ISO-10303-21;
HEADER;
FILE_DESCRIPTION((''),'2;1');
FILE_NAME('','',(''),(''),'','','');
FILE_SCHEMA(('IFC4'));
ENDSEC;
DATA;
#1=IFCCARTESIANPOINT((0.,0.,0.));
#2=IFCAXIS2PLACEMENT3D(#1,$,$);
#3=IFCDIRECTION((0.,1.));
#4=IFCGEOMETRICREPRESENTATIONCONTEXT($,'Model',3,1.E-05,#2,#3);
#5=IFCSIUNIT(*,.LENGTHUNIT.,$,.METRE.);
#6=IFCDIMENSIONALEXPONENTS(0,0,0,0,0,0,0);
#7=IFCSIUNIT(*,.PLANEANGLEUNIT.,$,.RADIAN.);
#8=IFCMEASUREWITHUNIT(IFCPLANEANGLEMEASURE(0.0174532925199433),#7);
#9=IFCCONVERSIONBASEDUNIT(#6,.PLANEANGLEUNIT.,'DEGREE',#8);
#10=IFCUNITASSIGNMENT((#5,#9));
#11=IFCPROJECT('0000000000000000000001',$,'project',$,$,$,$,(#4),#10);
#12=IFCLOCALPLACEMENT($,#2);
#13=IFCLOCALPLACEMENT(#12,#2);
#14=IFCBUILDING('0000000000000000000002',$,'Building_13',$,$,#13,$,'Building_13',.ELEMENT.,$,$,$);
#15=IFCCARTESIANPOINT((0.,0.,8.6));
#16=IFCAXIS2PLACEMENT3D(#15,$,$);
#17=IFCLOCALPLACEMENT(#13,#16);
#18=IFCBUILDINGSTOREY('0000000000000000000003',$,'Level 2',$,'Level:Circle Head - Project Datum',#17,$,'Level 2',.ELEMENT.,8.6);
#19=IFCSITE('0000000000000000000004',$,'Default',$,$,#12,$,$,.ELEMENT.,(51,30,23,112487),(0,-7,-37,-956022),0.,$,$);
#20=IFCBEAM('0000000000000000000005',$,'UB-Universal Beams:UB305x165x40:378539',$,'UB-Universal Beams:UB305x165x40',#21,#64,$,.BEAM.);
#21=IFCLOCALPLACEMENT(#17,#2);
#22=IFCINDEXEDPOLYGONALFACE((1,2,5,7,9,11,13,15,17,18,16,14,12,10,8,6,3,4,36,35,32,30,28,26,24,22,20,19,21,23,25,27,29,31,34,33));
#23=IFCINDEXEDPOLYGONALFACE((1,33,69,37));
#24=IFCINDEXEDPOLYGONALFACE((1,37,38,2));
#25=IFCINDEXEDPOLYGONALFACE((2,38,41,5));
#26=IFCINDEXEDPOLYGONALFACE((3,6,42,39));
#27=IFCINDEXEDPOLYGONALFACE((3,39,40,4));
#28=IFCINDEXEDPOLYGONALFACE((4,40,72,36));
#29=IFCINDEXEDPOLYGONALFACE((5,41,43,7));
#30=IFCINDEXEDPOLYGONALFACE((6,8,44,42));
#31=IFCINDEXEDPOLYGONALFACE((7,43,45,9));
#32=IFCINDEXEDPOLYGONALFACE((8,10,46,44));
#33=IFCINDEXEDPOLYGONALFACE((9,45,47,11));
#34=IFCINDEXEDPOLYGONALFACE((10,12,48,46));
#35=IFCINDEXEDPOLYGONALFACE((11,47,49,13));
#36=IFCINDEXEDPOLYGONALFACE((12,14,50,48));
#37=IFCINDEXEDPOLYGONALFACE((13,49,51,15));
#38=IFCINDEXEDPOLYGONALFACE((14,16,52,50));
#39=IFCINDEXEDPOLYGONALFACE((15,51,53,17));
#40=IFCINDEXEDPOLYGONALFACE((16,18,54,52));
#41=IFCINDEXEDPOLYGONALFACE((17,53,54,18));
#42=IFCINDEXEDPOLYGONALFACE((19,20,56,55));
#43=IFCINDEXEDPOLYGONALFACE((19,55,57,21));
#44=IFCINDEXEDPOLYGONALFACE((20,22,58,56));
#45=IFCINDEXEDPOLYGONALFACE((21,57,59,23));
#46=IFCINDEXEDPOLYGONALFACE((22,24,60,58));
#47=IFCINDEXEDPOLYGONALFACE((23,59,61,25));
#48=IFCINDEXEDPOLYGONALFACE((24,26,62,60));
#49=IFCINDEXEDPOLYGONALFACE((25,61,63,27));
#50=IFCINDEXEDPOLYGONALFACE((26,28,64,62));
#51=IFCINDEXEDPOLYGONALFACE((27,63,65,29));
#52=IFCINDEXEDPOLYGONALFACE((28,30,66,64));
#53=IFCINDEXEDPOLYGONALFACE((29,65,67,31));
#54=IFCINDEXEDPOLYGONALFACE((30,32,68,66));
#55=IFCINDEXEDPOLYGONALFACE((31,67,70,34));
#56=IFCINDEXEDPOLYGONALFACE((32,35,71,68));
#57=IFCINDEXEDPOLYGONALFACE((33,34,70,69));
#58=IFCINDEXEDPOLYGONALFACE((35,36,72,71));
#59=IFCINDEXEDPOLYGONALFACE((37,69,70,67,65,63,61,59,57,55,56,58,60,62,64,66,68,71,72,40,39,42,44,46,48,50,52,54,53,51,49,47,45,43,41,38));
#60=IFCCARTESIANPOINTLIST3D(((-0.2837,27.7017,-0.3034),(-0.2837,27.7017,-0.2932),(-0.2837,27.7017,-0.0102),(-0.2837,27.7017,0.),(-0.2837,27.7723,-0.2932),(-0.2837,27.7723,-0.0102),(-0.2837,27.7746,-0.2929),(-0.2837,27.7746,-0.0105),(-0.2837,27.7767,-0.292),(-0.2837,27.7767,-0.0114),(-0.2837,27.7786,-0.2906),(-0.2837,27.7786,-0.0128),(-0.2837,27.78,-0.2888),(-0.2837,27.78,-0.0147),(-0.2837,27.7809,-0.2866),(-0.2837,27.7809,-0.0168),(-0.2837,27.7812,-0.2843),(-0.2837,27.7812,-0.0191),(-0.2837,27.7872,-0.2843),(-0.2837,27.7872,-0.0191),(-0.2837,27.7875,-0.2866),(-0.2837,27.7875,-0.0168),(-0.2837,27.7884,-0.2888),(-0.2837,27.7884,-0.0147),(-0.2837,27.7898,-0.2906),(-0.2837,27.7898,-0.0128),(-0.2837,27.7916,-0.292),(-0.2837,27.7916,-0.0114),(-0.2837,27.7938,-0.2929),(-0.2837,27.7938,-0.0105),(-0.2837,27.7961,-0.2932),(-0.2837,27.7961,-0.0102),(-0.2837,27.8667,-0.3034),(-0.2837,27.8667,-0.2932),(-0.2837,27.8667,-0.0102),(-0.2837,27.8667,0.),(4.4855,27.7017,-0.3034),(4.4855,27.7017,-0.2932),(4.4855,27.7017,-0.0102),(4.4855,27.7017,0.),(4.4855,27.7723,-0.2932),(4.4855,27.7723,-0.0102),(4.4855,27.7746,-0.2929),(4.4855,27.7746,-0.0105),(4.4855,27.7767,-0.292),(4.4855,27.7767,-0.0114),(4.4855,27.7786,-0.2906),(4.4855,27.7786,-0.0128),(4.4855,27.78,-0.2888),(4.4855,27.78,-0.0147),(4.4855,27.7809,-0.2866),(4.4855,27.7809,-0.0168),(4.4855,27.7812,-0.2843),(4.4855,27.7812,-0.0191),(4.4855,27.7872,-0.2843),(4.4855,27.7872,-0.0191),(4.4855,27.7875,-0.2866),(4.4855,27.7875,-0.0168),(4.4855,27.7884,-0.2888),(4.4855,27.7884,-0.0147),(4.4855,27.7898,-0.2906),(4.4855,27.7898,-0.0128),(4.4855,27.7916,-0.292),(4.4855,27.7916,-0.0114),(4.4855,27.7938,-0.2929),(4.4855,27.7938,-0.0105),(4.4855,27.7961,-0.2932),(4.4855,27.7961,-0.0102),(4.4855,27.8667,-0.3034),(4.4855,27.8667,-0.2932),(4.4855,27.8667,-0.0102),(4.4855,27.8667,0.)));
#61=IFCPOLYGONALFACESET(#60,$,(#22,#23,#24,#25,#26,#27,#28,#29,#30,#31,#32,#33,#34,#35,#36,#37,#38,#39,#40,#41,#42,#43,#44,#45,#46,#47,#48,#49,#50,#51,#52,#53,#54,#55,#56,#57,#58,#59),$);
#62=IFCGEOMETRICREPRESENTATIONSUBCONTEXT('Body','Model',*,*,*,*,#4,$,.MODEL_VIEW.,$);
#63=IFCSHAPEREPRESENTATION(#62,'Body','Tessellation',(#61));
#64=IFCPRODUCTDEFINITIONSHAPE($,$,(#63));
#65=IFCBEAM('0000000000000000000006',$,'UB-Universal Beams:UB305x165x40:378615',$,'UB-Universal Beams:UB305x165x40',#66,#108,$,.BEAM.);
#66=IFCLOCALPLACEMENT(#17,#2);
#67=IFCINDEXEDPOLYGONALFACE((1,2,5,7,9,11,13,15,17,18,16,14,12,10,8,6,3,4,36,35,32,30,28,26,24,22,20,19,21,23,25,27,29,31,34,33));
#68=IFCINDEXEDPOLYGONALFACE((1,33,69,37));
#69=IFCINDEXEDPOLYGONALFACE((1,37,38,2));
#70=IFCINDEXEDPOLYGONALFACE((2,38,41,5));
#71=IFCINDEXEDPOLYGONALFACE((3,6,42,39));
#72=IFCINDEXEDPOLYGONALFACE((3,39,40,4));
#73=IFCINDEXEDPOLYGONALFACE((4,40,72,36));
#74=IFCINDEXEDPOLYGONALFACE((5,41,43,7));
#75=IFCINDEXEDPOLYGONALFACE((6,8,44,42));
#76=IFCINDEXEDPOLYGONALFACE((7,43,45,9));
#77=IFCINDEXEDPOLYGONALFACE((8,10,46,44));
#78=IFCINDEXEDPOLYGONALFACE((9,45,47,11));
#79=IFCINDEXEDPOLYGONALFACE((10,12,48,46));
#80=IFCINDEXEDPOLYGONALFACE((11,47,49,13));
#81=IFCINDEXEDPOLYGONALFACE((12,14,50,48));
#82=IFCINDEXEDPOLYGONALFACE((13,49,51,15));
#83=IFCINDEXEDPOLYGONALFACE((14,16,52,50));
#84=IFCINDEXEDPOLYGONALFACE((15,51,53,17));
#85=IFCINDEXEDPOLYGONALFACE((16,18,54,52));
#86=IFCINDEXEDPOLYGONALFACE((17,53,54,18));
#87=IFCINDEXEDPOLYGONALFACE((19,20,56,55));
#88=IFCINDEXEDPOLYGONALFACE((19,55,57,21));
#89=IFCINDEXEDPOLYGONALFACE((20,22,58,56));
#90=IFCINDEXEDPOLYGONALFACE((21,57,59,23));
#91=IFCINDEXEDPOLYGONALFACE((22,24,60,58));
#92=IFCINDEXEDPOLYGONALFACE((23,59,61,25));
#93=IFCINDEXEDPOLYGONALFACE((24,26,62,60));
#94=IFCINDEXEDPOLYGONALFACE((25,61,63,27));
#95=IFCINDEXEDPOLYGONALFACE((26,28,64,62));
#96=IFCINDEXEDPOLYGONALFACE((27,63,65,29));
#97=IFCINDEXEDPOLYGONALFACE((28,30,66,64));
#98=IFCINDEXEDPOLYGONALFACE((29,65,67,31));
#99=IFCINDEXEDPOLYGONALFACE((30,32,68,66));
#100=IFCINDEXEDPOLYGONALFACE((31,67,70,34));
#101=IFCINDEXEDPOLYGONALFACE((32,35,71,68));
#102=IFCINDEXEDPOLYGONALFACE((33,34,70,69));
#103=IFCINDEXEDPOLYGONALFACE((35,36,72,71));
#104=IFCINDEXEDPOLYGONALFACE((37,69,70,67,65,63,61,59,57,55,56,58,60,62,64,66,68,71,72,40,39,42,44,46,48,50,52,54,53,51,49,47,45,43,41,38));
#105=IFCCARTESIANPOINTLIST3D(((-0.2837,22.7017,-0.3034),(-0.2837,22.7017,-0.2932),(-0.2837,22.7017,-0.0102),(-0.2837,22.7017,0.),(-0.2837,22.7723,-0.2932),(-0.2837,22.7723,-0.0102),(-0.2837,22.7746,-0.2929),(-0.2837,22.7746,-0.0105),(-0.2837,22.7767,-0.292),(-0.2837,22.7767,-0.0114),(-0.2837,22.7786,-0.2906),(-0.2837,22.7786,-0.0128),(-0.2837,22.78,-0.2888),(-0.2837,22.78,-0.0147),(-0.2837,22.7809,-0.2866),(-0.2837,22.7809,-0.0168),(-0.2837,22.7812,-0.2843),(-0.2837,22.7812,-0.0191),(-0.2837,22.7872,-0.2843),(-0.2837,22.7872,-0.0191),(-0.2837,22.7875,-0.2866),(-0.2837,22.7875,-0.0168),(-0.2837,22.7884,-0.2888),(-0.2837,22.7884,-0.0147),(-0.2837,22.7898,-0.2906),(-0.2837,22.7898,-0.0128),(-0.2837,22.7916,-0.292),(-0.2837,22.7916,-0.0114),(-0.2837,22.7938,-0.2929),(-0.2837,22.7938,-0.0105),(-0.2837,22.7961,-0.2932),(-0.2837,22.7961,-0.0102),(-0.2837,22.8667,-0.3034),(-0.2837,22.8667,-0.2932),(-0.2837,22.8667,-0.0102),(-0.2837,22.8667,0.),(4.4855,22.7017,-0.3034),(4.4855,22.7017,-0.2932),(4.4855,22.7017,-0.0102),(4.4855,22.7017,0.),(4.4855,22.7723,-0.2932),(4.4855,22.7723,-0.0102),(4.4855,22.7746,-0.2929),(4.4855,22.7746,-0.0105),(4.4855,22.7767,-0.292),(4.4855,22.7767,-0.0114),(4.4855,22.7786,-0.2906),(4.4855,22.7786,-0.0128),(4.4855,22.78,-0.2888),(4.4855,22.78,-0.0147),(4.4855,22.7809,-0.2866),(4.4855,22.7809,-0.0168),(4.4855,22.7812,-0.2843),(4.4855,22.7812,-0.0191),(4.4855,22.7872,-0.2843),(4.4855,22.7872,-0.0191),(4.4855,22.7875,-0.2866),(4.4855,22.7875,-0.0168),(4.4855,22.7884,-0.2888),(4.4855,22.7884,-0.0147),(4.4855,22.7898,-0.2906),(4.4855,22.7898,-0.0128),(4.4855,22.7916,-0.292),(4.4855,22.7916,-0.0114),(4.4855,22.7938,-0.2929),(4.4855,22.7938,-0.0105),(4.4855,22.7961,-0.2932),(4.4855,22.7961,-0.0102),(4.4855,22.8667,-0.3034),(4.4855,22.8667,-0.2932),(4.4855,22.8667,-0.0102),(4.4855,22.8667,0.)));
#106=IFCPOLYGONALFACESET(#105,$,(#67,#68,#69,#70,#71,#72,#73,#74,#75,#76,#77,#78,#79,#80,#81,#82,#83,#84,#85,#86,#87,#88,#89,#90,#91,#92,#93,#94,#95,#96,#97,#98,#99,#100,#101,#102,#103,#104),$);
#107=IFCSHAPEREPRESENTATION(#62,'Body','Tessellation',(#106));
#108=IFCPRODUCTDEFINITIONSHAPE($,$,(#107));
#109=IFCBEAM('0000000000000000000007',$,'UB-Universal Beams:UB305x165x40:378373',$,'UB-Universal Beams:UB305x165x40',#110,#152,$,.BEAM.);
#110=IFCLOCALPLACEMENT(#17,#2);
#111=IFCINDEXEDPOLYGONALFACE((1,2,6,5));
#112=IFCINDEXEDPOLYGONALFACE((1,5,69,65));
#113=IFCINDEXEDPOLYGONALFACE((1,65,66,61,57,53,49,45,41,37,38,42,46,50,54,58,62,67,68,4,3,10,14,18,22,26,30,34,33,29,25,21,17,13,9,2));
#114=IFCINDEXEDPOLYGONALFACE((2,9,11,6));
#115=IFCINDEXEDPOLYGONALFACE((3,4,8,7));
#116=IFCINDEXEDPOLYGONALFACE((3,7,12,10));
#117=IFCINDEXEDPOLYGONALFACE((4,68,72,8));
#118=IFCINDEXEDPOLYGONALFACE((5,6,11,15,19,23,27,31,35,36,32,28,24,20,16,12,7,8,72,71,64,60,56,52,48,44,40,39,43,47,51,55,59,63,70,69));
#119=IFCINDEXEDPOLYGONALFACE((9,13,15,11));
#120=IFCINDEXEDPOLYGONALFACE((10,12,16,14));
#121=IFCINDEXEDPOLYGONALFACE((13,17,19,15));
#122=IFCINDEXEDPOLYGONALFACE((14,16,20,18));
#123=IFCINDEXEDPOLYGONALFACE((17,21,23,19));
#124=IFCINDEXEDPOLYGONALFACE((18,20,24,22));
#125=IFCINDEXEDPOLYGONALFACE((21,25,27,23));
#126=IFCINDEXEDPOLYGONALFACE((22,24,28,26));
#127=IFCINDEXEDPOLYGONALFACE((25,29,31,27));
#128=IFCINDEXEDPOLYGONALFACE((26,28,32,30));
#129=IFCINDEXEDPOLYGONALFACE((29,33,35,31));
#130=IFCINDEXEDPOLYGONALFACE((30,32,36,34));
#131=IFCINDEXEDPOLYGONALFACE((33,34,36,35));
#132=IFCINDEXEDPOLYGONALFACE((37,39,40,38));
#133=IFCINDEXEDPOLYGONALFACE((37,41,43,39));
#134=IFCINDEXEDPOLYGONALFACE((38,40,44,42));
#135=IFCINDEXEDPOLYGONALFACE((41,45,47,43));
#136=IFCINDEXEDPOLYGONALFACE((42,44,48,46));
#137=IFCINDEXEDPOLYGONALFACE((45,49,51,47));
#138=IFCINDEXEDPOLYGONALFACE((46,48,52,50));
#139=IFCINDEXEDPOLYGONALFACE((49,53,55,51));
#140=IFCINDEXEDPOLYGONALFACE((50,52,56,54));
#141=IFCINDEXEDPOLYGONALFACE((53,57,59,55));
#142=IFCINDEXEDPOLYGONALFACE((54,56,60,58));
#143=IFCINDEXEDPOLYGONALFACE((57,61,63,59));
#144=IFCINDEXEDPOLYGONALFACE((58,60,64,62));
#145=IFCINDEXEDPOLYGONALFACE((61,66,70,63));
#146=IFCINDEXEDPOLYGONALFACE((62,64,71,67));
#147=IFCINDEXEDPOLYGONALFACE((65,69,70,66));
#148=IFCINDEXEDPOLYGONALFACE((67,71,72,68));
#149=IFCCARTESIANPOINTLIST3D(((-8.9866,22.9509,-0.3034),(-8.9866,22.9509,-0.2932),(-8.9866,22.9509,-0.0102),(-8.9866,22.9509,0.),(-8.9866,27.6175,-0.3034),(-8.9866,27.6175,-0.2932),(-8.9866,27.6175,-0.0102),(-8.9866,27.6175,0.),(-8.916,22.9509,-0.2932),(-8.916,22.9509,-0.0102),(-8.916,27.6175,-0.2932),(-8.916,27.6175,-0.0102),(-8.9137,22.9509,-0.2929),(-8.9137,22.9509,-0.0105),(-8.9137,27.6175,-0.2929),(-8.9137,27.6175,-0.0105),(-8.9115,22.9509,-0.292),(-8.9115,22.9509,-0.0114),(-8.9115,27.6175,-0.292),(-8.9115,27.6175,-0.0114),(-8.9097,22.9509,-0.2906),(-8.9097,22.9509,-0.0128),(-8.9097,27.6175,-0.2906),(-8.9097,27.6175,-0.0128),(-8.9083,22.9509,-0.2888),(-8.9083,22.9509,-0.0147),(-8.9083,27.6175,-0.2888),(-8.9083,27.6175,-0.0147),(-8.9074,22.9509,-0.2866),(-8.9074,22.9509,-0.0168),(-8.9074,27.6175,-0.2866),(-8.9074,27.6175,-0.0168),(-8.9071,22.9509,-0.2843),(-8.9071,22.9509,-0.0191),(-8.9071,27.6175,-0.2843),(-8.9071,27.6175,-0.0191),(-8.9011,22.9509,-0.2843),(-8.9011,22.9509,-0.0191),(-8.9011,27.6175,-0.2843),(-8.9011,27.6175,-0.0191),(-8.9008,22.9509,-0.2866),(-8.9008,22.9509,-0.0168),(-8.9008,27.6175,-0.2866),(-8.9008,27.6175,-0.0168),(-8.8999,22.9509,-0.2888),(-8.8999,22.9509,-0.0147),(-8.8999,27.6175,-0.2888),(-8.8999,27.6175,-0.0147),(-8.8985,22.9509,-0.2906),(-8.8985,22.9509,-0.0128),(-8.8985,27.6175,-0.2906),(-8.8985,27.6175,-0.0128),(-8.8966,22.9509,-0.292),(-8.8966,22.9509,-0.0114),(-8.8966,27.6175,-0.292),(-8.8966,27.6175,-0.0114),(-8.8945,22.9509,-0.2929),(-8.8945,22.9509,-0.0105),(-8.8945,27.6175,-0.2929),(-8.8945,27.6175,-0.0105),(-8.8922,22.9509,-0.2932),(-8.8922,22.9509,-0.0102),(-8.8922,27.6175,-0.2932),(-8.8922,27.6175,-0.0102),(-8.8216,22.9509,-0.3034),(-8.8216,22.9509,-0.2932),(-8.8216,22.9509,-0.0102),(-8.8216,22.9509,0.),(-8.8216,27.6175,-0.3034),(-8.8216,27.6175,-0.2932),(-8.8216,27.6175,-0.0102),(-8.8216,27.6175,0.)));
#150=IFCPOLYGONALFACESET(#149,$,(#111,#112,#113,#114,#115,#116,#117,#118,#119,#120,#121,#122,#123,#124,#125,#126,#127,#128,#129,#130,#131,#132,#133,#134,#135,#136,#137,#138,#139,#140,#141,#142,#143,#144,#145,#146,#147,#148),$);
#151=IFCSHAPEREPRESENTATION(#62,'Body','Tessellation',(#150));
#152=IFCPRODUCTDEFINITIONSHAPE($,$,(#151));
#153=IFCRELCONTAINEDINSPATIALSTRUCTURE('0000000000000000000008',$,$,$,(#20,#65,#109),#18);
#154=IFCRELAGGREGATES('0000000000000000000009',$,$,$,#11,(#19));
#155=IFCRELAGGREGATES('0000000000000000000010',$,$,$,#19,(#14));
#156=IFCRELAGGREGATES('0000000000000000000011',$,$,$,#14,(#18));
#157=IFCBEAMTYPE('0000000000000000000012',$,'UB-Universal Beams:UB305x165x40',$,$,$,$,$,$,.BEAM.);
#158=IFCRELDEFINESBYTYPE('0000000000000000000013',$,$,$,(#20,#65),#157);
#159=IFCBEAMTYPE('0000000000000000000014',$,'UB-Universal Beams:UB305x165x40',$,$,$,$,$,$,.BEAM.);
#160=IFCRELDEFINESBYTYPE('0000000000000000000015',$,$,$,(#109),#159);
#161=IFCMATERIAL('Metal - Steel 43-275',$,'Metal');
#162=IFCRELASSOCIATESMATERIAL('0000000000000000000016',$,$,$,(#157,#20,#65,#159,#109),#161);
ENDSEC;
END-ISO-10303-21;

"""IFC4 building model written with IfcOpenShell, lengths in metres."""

from ifc_helpers import new_model, entity, si_unit, converted_unit, direction, frame, origin, place, context, subcontext, project, spatial, line, arc, indexed_curve, outline, extrude, source, transform, mapped, material, type_object, type_shapes, element, save


model = new_model("IFC4")

# Units and contexts
model_context = context("Model", 3, precision=1e-05, world=origin(), true_north=direction((0.0, 1.0)))
body_context = subcontext(model_context, "Body", "Model", "MODEL_VIEW")
ifc_project = project(units=[si_unit("LENGTHUNIT", "METRE"), converted_unit("PLANEANGLEUNIT", "DEGREE", entity("IfcPlaneAngleMeasure", 0.0174532925199433), si_unit("PLANEANGLEUNIT", "RADIAN"), dimensions=[0, 0, 0, 0, 0, 0, 0])], contexts=[model_context])

# Site, building, storey
site_placement = place(None, origin())
site = spatial("IfcSite", under=ifc_project, at=site_placement, Name="Default", CompositionType="ELEMENT", RefLatitude=(51, 30, 23, 112487), RefLongitude=(0, -7, -37, -956022), RefElevation=0.0)
building_placement = place(site_placement, origin())
building = spatial("IfcBuilding", under=site, at=building_placement, Name="Building_13", LongName="Building_13", CompositionType="ELEMENT")
storey_placement = place(building_placement, frame((0.0, 0.0, 8.6)))
storey = spatial("IfcBuildingStorey", under=building, at=storey_placement, Name="Level 2", ObjectType="Level:Circle Head - Project Datum", LongName="Level 2", CompositionType="ELEMENT", Elevation=8.6)

# Beams
ifc_material_1 = material(Name="Metal - Steel 43-275", Category="Metal")
beam_type_1 = type_object("IfcBeamType", Name="UB-Universal Beams:UB305x165x40", PredefinedType="BEAM", material=ifc_material_1)
shared_shape_1 = source(origin(), body_context, "Body", "SweptSolid", [
    extrude(outline(indexed_curve([(-0.0825, -0.1415), (-0.0825, -0.1517), (0.0825, -0.1517), (0.0825, -0.1415), (0.0119, -0.1415), (0.0056, -0.1389), (0.003, -0.1326), (0.003, 0.1326), (0.0056, 0.1389), (0.0119, 0.1415), (0.0825, 0.1415), (0.0825, 0.1517), (-0.0825, 0.1517), (-0.0825, 0.1415), (-0.0119, 0.1415), (-0.0056, 0.1389), (-0.003, 0.1326), (-0.003, -0.1326), (-0.0056, -0.1389), (-0.0119, -0.1415)], segments=[line(1, 2, 3, 4, 5), arc(5, 6, 7), line(7, 8), arc(8, 9, 10), line(10, 11, 12, 13, 14, 15), arc(15, 16, 17), line(17, 18), arc(18, 19, 20), line(20, 1)], self_intersect=False)), frame((-2.3846, 0.0, 0.0), z_axis=(-1.0, 0.0, 0.0), x_axis=(0.0, -1.0, 0.0)), (0.0, 0.0, -1.0), 4.7692),
])
type_shapes(beam_type_1, [shared_shape_1])
beam_1_placement = place(storey_placement, frame((2.1009, 27.7842, -0.1517)))
element("IfcBeam", 1, at=beam_1_placement, inside=storey, type_object=beam_type_1, material=ifc_material_1, Name="UB-Universal Beams:UB305x165x40:378539", ObjectType="UB-Universal Beams:UB305x165x40", PredefinedType="BEAM", context=body_context, shape_type="MappedRepresentation", body=[
    mapped(shared_shape_1, transform((0.0, 0.0, 0.0), scale=1.0)),
])
beam_2_placement = place(storey_placement, frame((2.1009, 22.7842, -0.1517), z_axis=(0.0, 0.0, 1.0), x_axis=(-1.0, 0.0, 0.0)))
element("IfcBeam", 2, at=beam_2_placement, inside=storey, type_object=beam_type_1, material=ifc_material_1, Name="UB-Universal Beams:UB305x165x40:378615", ObjectType="UB-Universal Beams:UB305x165x40", PredefinedType="BEAM", context=body_context, shape_type="MappedRepresentation", body=[
    mapped(shared_shape_1, transform((0.0, 0.0, 0.0), scale=1.0)),
])
beam_type_2 = type_object("IfcBeamType", Name="UB-Universal Beams:UB305x165x40", PredefinedType="BEAM", material=ifc_material_1)
shared_shape_2 = source(origin(), body_context, "Body", "SweptSolid", [
    extrude(outline(indexed_curve([(-0.0825, -0.1415), (-0.0825, -0.1517), (0.0825, -0.1517), (0.0825, -0.1415), (0.0119, -0.1415), (0.0056, -0.1389), (0.003, -0.1326), (0.003, 0.1326), (0.0056, 0.1389), (0.0119, 0.1415), (0.0825, 0.1415), (0.0825, 0.1517), (-0.0825, 0.1517), (-0.0825, 0.1415), (-0.0119, 0.1415), (-0.0056, 0.1389), (-0.003, 0.1326), (-0.003, -0.1326), (-0.0056, -0.1389), (-0.0119, -0.1415)], segments=[line(1, 2, 3, 4, 5), arc(5, 6, 7), line(7, 8), arc(8, 9, 10), line(10, 11, 12, 13, 14, 15), arc(15, 16, 17), line(17, 18), arc(18, 19, 20), line(20, 1)], self_intersect=False)), frame((-2.3333, 0.0, 0.0), z_axis=(-1.0, 0.0, 0.0), x_axis=(0.0, -1.0, 0.0)), (0.0, 0.0, -1.0), 4.6666),
])
type_shapes(beam_type_2, [shared_shape_2])
for number, where, z_axis, x_axis, name in (
    (3, (-8.9041, 25.2842, -0.1517), (0.0, 0.0, 1.0), (0.0, -1.0, 0.0), "UB-Universal Beams:UB305x165x40:378373"),
):
    element("IfcBeam", number, at=place(storey_placement, frame(where, z_axis=z_axis, x_axis=x_axis)), inside=storey, type_object=beam_type_2, material=ifc_material_1, Name=name, ObjectType="UB-Universal Beams:UB305x165x40", PredefinedType="BEAM", context=body_context, shape_type="MappedRepresentation", body=[
        mapped(shared_shape_2, transform((0.0, 0.0, 0.0), scale=1.0)),
    ])

save(model, "model.ifc")
